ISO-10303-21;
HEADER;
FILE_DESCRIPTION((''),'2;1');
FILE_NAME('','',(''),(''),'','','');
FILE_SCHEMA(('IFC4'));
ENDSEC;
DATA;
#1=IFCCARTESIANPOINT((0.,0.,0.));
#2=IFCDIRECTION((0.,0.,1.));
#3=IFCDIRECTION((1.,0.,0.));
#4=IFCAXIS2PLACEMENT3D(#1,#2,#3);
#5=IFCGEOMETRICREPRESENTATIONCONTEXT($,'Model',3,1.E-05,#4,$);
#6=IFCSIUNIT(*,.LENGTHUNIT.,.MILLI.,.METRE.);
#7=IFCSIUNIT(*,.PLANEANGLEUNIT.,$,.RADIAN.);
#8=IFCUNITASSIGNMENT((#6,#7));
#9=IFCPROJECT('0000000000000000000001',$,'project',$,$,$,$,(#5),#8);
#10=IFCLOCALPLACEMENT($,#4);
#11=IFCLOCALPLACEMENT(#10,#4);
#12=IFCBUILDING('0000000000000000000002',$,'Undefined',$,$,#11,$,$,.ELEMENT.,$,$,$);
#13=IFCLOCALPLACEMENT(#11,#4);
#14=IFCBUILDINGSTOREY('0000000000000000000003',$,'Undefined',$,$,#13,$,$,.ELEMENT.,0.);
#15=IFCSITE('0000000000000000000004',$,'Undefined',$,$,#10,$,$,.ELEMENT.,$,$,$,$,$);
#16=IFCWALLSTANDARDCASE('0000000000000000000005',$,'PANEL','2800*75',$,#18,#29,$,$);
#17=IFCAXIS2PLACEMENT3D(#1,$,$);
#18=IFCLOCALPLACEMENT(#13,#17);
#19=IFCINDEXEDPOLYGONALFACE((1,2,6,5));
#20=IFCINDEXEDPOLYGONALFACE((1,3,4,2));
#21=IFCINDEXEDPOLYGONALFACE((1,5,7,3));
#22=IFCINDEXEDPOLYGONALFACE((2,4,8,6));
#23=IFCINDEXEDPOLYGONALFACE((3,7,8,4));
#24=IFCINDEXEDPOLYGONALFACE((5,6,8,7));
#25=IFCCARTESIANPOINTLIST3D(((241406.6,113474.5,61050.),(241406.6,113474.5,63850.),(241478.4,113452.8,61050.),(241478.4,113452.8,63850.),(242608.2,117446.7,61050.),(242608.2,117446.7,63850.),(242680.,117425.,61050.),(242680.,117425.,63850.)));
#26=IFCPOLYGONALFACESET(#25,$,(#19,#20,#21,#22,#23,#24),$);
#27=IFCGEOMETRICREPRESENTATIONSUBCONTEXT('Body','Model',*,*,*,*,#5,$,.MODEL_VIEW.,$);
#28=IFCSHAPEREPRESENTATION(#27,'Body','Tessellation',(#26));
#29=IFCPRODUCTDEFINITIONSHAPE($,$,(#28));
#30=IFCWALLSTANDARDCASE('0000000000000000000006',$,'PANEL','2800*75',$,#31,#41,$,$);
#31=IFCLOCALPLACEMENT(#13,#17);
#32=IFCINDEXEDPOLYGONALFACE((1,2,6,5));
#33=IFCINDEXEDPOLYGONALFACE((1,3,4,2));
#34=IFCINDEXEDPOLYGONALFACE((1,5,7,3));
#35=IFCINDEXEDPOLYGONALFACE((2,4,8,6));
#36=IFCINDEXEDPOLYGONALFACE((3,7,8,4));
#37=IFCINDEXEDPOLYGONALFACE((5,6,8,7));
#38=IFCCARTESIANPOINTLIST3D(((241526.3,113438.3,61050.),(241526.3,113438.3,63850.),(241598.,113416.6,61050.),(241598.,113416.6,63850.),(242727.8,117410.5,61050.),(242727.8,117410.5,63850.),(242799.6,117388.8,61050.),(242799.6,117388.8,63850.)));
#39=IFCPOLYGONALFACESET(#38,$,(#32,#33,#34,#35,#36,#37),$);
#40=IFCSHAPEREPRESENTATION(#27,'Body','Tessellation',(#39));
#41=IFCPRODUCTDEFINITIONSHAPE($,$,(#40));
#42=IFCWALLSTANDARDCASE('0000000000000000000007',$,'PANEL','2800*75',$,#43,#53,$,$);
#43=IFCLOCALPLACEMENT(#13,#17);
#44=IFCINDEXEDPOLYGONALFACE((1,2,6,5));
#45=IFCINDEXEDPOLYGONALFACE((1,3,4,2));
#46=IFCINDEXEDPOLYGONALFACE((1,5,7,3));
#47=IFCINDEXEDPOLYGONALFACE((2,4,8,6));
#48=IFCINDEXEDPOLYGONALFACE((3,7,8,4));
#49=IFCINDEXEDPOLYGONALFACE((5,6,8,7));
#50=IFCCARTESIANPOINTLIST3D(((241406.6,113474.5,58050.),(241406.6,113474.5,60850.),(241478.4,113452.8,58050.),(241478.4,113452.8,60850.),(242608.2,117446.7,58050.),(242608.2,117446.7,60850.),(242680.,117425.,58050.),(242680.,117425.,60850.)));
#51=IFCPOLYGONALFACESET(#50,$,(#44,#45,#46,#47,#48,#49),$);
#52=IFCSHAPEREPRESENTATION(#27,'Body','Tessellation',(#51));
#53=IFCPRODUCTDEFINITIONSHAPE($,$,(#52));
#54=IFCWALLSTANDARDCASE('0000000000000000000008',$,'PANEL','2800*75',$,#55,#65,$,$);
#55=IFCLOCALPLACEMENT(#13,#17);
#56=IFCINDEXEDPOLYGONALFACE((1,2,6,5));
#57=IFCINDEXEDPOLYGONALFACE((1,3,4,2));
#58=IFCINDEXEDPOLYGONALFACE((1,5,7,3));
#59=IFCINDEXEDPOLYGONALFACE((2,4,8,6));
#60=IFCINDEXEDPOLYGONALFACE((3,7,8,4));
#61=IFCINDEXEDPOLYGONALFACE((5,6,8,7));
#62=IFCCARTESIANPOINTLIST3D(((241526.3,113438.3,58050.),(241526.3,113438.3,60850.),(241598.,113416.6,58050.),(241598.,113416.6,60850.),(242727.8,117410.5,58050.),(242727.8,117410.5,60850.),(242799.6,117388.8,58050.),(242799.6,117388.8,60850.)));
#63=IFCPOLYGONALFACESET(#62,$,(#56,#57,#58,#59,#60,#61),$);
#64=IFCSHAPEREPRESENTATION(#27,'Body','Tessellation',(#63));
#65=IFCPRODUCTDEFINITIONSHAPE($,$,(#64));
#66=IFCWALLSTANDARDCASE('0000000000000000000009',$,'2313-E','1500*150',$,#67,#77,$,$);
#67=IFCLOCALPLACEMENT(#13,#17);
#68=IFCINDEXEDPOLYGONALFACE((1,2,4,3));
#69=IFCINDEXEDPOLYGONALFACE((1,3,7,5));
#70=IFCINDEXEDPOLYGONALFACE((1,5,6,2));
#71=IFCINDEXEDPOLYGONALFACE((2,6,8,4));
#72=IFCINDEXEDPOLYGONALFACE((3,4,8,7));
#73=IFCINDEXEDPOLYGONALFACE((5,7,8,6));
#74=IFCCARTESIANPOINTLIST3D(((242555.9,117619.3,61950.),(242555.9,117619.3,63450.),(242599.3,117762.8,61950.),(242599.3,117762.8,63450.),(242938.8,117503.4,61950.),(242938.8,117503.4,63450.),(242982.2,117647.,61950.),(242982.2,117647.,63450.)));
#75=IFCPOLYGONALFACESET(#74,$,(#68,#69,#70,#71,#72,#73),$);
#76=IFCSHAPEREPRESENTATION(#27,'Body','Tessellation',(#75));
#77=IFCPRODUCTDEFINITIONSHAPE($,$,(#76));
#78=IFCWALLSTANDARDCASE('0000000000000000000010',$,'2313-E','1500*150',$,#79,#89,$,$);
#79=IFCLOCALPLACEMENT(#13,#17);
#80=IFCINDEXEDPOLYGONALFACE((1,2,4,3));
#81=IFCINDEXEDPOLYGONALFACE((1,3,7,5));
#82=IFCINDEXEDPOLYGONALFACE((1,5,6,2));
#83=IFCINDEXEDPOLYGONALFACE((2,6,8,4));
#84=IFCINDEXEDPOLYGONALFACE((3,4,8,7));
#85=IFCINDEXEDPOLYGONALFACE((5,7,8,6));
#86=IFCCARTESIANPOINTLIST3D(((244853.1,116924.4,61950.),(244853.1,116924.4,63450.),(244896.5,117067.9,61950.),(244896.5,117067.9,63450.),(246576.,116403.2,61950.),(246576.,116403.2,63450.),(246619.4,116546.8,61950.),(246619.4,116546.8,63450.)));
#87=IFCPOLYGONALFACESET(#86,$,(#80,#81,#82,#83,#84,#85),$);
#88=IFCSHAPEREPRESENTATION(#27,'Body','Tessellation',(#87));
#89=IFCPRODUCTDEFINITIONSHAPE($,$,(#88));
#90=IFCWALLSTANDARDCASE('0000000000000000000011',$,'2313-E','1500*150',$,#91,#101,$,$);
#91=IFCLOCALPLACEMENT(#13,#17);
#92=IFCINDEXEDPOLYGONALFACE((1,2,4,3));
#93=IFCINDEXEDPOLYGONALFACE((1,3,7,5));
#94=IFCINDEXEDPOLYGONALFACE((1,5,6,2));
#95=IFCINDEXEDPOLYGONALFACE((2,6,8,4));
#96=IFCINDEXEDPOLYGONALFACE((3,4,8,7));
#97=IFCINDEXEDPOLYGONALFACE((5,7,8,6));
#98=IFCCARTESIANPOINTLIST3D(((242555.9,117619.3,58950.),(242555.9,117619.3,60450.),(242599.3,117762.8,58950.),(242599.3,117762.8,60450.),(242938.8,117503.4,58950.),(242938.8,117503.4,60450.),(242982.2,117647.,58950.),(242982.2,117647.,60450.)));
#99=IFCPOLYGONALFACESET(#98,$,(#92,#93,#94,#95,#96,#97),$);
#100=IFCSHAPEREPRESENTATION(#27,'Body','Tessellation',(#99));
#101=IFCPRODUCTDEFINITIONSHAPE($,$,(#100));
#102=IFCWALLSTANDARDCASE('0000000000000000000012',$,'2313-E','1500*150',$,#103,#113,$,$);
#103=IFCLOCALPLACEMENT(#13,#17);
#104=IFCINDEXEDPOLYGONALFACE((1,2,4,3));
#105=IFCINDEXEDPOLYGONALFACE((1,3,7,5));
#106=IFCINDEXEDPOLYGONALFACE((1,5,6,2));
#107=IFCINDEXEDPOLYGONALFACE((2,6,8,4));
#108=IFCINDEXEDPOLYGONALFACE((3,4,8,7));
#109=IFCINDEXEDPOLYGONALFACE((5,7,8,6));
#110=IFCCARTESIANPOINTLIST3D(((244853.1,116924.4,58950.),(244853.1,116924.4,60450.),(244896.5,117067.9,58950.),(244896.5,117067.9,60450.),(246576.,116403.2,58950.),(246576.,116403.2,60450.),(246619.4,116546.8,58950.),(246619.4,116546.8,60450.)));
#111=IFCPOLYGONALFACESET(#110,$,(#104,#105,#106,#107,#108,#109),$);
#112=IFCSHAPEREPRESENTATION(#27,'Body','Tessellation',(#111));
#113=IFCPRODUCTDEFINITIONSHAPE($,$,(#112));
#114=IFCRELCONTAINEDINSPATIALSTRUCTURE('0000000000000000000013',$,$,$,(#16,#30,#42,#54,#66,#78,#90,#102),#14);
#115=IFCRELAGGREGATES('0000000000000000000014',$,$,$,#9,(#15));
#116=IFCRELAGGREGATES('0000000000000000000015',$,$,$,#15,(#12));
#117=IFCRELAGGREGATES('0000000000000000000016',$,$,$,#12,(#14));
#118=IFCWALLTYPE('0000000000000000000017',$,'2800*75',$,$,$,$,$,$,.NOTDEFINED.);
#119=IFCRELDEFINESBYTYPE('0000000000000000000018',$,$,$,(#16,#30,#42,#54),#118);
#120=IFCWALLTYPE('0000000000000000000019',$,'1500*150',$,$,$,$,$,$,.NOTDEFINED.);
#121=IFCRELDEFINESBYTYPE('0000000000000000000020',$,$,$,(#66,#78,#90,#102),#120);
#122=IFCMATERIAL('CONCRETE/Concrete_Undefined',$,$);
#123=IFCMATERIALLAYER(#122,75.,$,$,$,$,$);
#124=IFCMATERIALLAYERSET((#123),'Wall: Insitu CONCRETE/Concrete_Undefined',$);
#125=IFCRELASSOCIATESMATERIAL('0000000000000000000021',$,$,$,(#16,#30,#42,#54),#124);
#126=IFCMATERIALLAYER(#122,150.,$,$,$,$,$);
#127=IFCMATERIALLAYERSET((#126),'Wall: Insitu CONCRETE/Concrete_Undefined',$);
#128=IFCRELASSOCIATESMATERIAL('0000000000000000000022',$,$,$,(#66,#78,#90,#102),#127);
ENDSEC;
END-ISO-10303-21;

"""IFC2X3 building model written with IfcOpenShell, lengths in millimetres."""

from ifc_helpers import new_model, si_unit, frame, frame_2d, origin_with_axes, place, context, subcontext, project, spatial, rectangle, extrude, material, layer, layer_set, layer_usage, type_object, element, save


model = new_model("IFC2X3")

# Units and contexts
model_context = context("Model", 3, precision=1e-05, world=origin_with_axes())
body_context = subcontext(model_context, "Body", "Model", "MODEL_VIEW")
ifc_project = project(units=[si_unit("LENGTHUNIT", "METRE", prefix="MILLI"), si_unit("PLANEANGLEUNIT", "RADIAN")], contexts=[model_context])

# Site, building, storey
site_placement = place(None, origin_with_axes())
site = spatial("IfcSite", under=ifc_project, at=site_placement, Name="Undefined", CompositionType="ELEMENT")
building_placement = place(site_placement, origin_with_axes())
building = spatial("IfcBuilding", under=site, at=building_placement, Name="Undefined", CompositionType="ELEMENT")
storey_placement = place(building_placement, origin_with_axes())
storey = spatial("IfcBuildingStorey", under=building, at=storey_placement, Name="Undefined", CompositionType="ELEMENT", Elevation=0.0)

# Shared definitions
ifc_material_1 = material(Name="CONCRETE/Concrete_Undefined")

# Walls
ifc_layer_1 = layer(ifc_material_1, 150.0)
ifc_layer_set_1 = layer_set([ifc_layer_1], Name="Wall: Insitu CONCRETE/Concrete_Undefined")
ifc_layer_2 = layer(ifc_material_1, 75.0)
ifc_layer_set_2 = layer_set([ifc_layer_2], Name="Wall: Insitu CONCRETE/Concrete_Undefined")
ifc_layer_usage_1 = layer_usage(ifc_layer_set_2, "AXIS2", "POSITIVE", -37.5)
wall_type_1 = type_object("IfcWallType", Name="2800*75", PredefinedType="NOTDEFINED")
wall_1_placement = place(storey_placement, frame((241442.5, 113463.6, 61050.0), z_axis=(0.0, 0.0, 1.0), x_axis=(0.289537, 0.957167, 0.0)))
element("IfcWallStandardCase", 1, at=wall_1_placement, inside=storey, type_object=wall_type_1, material=ifc_layer_usage_1, Name="PANEL", Description="2800*75", context=body_context, shape_type="SweptSolid", body=[
    extrude(rectangle(XDim=4150.0, YDim=75.0, at=frame_2d((0.0, 2075.0), x_axis=(0.0, -1.0))), frame((0.0, 0.0, 0.0), z_axis=(0.0, 0.0, 1.0), x_axis=(0.0, -1.0, 0.0)), (0.0, 0.0, 1.0), 2800.0),
])
ifc_layer_usage_2 = layer_usage(ifc_layer_set_2, "AXIS2", "POSITIVE", -37.5)
wall_2_placement = place(storey_placement, frame((241562.1, 113427.4, 61050.0), z_axis=(0.0, 0.0, 1.0), x_axis=(0.289537, 0.957167, 0.0)))
element("IfcWallStandardCase", 2, at=wall_2_placement, inside=storey, type_object=wall_type_1, material=ifc_layer_usage_2, Name="PANEL", Description="2800*75", context=body_context, shape_type="SweptSolid", body=[
    extrude(rectangle(XDim=4150.0, YDim=75.0, at=frame_2d((0.0, 2075.0), x_axis=(0.0, -1.0))), frame((0.0, 0.0, 0.0), z_axis=(0.0, 0.0, 1.0), x_axis=(0.0, -1.0, 0.0)), (0.0, 0.0, 1.0), 2800.0),
])
ifc_layer_usage_3 = layer_usage(ifc_layer_set_2, "AXIS2", "POSITIVE", -37.5)
wall_3_placement = place(storey_placement, frame((241442.5, 113463.6, 58050.0), z_axis=(0.0, 0.0, 1.0), x_axis=(0.289537, 0.957167, 0.0)))
element("IfcWallStandardCase", 3, at=wall_3_placement, inside=storey, type_object=wall_type_1, material=ifc_layer_usage_3, Name="PANEL", Description="2800*75", context=body_context, shape_type="SweptSolid", body=[
    extrude(rectangle(XDim=4150.0, YDim=75.0, at=frame_2d((0.0, 2075.0), x_axis=(0.0, -1.0))), frame((0.0, 0.0, 0.0), z_axis=(0.0, 0.0, 1.0), x_axis=(0.0, -1.0, 0.0)), (0.0, 0.0, 1.0), 2800.0),
])
ifc_layer_usage_4 = layer_usage(ifc_layer_set_2, "AXIS2", "POSITIVE", -37.5)
wall_4_placement = place(storey_placement, frame((241562.1, 113427.4, 58050.0), z_axis=(0.0, 0.0, 1.0), x_axis=(0.289537, 0.957167, 0.0)))
element("IfcWallStandardCase", 4, at=wall_4_placement, inside=storey, type_object=wall_type_1, material=ifc_layer_usage_4, Name="PANEL", Description="2800*75", context=body_context, shape_type="SweptSolid", body=[
    extrude(rectangle(XDim=4150.0, YDim=75.0, at=frame_2d((0.0, 2075.0), x_axis=(0.0, -1.0))), frame((0.0, 0.0, 0.0), z_axis=(0.0, 0.0, 1.0), x_axis=(0.0, -1.0, 0.0)), (0.0, 0.0, 1.0), 2800.0),
])
ifc_layer_usage_5 = layer_usage(ifc_layer_set_1, "AXIS2", "POSITIVE", -75.0)
wall_type_2 = type_object("IfcWallType", Name="1500*150", PredefinedType="NOTDEFINED")
wall_5_placement = place(storey_placement, frame((242577.6, 117691.0, 61950.0), z_axis=(0.0, 0.0, 1.0), x_axis=(0.957161, -0.289556, 0.0)))
element("IfcWallStandardCase", 5, at=wall_5_placement, inside=storey, type_object=wall_type_2, material=ifc_layer_usage_5, Name="2313-E", Description="1500*150", context=body_context, shape_type="SweptSolid", body=[
    extrude(rectangle(XDim=400.0, YDim=150.0, at=frame_2d((0.0, 200.0), x_axis=(0.0, -1.0))), frame((0.0, 0.0, 0.0), z_axis=(0.0, 0.0, 1.0), x_axis=(0.0, -1.0, 0.0)), (0.0, 0.0, 1.0), 1500.0),
])
ifc_layer_usage_6 = layer_usage(ifc_layer_set_1, "AXIS2", "POSITIVE", -75.0)
wall_6_placement = place(storey_placement, frame((244874.8, 116996.2, 61950.0), z_axis=(0.0, 0.0, 1.0), x_axis=(0.957166, -0.289541, 0.0)))
element("IfcWallStandardCase", 6, at=wall_6_placement, inside=storey, type_object=wall_type_2, material=ifc_layer_usage_6, Name="2313-E", Description="1500*150", context=body_context, shape_type="SweptSolid", body=[
    extrude(rectangle(XDim=1800.0, YDim=150.0, at=frame_2d((0.0, 900.0), x_axis=(0.0, -1.0))), frame((0.0, 0.0, 0.0), z_axis=(0.0, 0.0, 1.0), x_axis=(0.0, -1.0, 0.0)), (0.0, 0.0, 1.0), 1500.0),
])
ifc_layer_usage_7 = layer_usage(ifc_layer_set_1, "AXIS2", "POSITIVE", -75.0)
wall_7_placement = place(storey_placement, frame((242577.6, 117691.0, 58950.0), z_axis=(0.0, 0.0, 1.0), x_axis=(0.957161, -0.289556, 0.0)))
element("IfcWallStandardCase", 7, at=wall_7_placement, inside=storey, type_object=wall_type_2, material=ifc_layer_usage_7, Name="2313-E", Description="1500*150", context=body_context, shape_type="SweptSolid", body=[
    extrude(rectangle(XDim=400.0, YDim=150.0, at=frame_2d((0.0, 200.0), x_axis=(0.0, -1.0))), frame((0.0, 0.0, 0.0), z_axis=(0.0, 0.0, 1.0), x_axis=(0.0, -1.0, 0.0)), (0.0, 0.0, 1.0), 1500.0),
])
ifc_layer_usage_8 = layer_usage(ifc_layer_set_1, "AXIS2", "POSITIVE", -75.0)
wall_8_placement = place(storey_placement, frame((244874.8, 116996.2, 58950.0), z_axis=(0.0, 0.0, 1.0), x_axis=(0.957166, -0.289541, 0.0)))
element("IfcWallStandardCase", 8, at=wall_8_placement, inside=storey, type_object=wall_type_2, material=ifc_layer_usage_8, Name="2313-E", Description="1500*150", context=body_context, shape_type="SweptSolid", body=[
    extrude(rectangle(XDim=1800.0, YDim=150.0, at=frame_2d((0.0, 900.0), x_axis=(0.0, -1.0))), frame((0.0, 0.0, 0.0), z_axis=(0.0, 0.0, 1.0), x_axis=(0.0, -1.0, 0.0)), (0.0, 0.0, 1.0), 1500.0),
])

save(model, "model.ifc")
